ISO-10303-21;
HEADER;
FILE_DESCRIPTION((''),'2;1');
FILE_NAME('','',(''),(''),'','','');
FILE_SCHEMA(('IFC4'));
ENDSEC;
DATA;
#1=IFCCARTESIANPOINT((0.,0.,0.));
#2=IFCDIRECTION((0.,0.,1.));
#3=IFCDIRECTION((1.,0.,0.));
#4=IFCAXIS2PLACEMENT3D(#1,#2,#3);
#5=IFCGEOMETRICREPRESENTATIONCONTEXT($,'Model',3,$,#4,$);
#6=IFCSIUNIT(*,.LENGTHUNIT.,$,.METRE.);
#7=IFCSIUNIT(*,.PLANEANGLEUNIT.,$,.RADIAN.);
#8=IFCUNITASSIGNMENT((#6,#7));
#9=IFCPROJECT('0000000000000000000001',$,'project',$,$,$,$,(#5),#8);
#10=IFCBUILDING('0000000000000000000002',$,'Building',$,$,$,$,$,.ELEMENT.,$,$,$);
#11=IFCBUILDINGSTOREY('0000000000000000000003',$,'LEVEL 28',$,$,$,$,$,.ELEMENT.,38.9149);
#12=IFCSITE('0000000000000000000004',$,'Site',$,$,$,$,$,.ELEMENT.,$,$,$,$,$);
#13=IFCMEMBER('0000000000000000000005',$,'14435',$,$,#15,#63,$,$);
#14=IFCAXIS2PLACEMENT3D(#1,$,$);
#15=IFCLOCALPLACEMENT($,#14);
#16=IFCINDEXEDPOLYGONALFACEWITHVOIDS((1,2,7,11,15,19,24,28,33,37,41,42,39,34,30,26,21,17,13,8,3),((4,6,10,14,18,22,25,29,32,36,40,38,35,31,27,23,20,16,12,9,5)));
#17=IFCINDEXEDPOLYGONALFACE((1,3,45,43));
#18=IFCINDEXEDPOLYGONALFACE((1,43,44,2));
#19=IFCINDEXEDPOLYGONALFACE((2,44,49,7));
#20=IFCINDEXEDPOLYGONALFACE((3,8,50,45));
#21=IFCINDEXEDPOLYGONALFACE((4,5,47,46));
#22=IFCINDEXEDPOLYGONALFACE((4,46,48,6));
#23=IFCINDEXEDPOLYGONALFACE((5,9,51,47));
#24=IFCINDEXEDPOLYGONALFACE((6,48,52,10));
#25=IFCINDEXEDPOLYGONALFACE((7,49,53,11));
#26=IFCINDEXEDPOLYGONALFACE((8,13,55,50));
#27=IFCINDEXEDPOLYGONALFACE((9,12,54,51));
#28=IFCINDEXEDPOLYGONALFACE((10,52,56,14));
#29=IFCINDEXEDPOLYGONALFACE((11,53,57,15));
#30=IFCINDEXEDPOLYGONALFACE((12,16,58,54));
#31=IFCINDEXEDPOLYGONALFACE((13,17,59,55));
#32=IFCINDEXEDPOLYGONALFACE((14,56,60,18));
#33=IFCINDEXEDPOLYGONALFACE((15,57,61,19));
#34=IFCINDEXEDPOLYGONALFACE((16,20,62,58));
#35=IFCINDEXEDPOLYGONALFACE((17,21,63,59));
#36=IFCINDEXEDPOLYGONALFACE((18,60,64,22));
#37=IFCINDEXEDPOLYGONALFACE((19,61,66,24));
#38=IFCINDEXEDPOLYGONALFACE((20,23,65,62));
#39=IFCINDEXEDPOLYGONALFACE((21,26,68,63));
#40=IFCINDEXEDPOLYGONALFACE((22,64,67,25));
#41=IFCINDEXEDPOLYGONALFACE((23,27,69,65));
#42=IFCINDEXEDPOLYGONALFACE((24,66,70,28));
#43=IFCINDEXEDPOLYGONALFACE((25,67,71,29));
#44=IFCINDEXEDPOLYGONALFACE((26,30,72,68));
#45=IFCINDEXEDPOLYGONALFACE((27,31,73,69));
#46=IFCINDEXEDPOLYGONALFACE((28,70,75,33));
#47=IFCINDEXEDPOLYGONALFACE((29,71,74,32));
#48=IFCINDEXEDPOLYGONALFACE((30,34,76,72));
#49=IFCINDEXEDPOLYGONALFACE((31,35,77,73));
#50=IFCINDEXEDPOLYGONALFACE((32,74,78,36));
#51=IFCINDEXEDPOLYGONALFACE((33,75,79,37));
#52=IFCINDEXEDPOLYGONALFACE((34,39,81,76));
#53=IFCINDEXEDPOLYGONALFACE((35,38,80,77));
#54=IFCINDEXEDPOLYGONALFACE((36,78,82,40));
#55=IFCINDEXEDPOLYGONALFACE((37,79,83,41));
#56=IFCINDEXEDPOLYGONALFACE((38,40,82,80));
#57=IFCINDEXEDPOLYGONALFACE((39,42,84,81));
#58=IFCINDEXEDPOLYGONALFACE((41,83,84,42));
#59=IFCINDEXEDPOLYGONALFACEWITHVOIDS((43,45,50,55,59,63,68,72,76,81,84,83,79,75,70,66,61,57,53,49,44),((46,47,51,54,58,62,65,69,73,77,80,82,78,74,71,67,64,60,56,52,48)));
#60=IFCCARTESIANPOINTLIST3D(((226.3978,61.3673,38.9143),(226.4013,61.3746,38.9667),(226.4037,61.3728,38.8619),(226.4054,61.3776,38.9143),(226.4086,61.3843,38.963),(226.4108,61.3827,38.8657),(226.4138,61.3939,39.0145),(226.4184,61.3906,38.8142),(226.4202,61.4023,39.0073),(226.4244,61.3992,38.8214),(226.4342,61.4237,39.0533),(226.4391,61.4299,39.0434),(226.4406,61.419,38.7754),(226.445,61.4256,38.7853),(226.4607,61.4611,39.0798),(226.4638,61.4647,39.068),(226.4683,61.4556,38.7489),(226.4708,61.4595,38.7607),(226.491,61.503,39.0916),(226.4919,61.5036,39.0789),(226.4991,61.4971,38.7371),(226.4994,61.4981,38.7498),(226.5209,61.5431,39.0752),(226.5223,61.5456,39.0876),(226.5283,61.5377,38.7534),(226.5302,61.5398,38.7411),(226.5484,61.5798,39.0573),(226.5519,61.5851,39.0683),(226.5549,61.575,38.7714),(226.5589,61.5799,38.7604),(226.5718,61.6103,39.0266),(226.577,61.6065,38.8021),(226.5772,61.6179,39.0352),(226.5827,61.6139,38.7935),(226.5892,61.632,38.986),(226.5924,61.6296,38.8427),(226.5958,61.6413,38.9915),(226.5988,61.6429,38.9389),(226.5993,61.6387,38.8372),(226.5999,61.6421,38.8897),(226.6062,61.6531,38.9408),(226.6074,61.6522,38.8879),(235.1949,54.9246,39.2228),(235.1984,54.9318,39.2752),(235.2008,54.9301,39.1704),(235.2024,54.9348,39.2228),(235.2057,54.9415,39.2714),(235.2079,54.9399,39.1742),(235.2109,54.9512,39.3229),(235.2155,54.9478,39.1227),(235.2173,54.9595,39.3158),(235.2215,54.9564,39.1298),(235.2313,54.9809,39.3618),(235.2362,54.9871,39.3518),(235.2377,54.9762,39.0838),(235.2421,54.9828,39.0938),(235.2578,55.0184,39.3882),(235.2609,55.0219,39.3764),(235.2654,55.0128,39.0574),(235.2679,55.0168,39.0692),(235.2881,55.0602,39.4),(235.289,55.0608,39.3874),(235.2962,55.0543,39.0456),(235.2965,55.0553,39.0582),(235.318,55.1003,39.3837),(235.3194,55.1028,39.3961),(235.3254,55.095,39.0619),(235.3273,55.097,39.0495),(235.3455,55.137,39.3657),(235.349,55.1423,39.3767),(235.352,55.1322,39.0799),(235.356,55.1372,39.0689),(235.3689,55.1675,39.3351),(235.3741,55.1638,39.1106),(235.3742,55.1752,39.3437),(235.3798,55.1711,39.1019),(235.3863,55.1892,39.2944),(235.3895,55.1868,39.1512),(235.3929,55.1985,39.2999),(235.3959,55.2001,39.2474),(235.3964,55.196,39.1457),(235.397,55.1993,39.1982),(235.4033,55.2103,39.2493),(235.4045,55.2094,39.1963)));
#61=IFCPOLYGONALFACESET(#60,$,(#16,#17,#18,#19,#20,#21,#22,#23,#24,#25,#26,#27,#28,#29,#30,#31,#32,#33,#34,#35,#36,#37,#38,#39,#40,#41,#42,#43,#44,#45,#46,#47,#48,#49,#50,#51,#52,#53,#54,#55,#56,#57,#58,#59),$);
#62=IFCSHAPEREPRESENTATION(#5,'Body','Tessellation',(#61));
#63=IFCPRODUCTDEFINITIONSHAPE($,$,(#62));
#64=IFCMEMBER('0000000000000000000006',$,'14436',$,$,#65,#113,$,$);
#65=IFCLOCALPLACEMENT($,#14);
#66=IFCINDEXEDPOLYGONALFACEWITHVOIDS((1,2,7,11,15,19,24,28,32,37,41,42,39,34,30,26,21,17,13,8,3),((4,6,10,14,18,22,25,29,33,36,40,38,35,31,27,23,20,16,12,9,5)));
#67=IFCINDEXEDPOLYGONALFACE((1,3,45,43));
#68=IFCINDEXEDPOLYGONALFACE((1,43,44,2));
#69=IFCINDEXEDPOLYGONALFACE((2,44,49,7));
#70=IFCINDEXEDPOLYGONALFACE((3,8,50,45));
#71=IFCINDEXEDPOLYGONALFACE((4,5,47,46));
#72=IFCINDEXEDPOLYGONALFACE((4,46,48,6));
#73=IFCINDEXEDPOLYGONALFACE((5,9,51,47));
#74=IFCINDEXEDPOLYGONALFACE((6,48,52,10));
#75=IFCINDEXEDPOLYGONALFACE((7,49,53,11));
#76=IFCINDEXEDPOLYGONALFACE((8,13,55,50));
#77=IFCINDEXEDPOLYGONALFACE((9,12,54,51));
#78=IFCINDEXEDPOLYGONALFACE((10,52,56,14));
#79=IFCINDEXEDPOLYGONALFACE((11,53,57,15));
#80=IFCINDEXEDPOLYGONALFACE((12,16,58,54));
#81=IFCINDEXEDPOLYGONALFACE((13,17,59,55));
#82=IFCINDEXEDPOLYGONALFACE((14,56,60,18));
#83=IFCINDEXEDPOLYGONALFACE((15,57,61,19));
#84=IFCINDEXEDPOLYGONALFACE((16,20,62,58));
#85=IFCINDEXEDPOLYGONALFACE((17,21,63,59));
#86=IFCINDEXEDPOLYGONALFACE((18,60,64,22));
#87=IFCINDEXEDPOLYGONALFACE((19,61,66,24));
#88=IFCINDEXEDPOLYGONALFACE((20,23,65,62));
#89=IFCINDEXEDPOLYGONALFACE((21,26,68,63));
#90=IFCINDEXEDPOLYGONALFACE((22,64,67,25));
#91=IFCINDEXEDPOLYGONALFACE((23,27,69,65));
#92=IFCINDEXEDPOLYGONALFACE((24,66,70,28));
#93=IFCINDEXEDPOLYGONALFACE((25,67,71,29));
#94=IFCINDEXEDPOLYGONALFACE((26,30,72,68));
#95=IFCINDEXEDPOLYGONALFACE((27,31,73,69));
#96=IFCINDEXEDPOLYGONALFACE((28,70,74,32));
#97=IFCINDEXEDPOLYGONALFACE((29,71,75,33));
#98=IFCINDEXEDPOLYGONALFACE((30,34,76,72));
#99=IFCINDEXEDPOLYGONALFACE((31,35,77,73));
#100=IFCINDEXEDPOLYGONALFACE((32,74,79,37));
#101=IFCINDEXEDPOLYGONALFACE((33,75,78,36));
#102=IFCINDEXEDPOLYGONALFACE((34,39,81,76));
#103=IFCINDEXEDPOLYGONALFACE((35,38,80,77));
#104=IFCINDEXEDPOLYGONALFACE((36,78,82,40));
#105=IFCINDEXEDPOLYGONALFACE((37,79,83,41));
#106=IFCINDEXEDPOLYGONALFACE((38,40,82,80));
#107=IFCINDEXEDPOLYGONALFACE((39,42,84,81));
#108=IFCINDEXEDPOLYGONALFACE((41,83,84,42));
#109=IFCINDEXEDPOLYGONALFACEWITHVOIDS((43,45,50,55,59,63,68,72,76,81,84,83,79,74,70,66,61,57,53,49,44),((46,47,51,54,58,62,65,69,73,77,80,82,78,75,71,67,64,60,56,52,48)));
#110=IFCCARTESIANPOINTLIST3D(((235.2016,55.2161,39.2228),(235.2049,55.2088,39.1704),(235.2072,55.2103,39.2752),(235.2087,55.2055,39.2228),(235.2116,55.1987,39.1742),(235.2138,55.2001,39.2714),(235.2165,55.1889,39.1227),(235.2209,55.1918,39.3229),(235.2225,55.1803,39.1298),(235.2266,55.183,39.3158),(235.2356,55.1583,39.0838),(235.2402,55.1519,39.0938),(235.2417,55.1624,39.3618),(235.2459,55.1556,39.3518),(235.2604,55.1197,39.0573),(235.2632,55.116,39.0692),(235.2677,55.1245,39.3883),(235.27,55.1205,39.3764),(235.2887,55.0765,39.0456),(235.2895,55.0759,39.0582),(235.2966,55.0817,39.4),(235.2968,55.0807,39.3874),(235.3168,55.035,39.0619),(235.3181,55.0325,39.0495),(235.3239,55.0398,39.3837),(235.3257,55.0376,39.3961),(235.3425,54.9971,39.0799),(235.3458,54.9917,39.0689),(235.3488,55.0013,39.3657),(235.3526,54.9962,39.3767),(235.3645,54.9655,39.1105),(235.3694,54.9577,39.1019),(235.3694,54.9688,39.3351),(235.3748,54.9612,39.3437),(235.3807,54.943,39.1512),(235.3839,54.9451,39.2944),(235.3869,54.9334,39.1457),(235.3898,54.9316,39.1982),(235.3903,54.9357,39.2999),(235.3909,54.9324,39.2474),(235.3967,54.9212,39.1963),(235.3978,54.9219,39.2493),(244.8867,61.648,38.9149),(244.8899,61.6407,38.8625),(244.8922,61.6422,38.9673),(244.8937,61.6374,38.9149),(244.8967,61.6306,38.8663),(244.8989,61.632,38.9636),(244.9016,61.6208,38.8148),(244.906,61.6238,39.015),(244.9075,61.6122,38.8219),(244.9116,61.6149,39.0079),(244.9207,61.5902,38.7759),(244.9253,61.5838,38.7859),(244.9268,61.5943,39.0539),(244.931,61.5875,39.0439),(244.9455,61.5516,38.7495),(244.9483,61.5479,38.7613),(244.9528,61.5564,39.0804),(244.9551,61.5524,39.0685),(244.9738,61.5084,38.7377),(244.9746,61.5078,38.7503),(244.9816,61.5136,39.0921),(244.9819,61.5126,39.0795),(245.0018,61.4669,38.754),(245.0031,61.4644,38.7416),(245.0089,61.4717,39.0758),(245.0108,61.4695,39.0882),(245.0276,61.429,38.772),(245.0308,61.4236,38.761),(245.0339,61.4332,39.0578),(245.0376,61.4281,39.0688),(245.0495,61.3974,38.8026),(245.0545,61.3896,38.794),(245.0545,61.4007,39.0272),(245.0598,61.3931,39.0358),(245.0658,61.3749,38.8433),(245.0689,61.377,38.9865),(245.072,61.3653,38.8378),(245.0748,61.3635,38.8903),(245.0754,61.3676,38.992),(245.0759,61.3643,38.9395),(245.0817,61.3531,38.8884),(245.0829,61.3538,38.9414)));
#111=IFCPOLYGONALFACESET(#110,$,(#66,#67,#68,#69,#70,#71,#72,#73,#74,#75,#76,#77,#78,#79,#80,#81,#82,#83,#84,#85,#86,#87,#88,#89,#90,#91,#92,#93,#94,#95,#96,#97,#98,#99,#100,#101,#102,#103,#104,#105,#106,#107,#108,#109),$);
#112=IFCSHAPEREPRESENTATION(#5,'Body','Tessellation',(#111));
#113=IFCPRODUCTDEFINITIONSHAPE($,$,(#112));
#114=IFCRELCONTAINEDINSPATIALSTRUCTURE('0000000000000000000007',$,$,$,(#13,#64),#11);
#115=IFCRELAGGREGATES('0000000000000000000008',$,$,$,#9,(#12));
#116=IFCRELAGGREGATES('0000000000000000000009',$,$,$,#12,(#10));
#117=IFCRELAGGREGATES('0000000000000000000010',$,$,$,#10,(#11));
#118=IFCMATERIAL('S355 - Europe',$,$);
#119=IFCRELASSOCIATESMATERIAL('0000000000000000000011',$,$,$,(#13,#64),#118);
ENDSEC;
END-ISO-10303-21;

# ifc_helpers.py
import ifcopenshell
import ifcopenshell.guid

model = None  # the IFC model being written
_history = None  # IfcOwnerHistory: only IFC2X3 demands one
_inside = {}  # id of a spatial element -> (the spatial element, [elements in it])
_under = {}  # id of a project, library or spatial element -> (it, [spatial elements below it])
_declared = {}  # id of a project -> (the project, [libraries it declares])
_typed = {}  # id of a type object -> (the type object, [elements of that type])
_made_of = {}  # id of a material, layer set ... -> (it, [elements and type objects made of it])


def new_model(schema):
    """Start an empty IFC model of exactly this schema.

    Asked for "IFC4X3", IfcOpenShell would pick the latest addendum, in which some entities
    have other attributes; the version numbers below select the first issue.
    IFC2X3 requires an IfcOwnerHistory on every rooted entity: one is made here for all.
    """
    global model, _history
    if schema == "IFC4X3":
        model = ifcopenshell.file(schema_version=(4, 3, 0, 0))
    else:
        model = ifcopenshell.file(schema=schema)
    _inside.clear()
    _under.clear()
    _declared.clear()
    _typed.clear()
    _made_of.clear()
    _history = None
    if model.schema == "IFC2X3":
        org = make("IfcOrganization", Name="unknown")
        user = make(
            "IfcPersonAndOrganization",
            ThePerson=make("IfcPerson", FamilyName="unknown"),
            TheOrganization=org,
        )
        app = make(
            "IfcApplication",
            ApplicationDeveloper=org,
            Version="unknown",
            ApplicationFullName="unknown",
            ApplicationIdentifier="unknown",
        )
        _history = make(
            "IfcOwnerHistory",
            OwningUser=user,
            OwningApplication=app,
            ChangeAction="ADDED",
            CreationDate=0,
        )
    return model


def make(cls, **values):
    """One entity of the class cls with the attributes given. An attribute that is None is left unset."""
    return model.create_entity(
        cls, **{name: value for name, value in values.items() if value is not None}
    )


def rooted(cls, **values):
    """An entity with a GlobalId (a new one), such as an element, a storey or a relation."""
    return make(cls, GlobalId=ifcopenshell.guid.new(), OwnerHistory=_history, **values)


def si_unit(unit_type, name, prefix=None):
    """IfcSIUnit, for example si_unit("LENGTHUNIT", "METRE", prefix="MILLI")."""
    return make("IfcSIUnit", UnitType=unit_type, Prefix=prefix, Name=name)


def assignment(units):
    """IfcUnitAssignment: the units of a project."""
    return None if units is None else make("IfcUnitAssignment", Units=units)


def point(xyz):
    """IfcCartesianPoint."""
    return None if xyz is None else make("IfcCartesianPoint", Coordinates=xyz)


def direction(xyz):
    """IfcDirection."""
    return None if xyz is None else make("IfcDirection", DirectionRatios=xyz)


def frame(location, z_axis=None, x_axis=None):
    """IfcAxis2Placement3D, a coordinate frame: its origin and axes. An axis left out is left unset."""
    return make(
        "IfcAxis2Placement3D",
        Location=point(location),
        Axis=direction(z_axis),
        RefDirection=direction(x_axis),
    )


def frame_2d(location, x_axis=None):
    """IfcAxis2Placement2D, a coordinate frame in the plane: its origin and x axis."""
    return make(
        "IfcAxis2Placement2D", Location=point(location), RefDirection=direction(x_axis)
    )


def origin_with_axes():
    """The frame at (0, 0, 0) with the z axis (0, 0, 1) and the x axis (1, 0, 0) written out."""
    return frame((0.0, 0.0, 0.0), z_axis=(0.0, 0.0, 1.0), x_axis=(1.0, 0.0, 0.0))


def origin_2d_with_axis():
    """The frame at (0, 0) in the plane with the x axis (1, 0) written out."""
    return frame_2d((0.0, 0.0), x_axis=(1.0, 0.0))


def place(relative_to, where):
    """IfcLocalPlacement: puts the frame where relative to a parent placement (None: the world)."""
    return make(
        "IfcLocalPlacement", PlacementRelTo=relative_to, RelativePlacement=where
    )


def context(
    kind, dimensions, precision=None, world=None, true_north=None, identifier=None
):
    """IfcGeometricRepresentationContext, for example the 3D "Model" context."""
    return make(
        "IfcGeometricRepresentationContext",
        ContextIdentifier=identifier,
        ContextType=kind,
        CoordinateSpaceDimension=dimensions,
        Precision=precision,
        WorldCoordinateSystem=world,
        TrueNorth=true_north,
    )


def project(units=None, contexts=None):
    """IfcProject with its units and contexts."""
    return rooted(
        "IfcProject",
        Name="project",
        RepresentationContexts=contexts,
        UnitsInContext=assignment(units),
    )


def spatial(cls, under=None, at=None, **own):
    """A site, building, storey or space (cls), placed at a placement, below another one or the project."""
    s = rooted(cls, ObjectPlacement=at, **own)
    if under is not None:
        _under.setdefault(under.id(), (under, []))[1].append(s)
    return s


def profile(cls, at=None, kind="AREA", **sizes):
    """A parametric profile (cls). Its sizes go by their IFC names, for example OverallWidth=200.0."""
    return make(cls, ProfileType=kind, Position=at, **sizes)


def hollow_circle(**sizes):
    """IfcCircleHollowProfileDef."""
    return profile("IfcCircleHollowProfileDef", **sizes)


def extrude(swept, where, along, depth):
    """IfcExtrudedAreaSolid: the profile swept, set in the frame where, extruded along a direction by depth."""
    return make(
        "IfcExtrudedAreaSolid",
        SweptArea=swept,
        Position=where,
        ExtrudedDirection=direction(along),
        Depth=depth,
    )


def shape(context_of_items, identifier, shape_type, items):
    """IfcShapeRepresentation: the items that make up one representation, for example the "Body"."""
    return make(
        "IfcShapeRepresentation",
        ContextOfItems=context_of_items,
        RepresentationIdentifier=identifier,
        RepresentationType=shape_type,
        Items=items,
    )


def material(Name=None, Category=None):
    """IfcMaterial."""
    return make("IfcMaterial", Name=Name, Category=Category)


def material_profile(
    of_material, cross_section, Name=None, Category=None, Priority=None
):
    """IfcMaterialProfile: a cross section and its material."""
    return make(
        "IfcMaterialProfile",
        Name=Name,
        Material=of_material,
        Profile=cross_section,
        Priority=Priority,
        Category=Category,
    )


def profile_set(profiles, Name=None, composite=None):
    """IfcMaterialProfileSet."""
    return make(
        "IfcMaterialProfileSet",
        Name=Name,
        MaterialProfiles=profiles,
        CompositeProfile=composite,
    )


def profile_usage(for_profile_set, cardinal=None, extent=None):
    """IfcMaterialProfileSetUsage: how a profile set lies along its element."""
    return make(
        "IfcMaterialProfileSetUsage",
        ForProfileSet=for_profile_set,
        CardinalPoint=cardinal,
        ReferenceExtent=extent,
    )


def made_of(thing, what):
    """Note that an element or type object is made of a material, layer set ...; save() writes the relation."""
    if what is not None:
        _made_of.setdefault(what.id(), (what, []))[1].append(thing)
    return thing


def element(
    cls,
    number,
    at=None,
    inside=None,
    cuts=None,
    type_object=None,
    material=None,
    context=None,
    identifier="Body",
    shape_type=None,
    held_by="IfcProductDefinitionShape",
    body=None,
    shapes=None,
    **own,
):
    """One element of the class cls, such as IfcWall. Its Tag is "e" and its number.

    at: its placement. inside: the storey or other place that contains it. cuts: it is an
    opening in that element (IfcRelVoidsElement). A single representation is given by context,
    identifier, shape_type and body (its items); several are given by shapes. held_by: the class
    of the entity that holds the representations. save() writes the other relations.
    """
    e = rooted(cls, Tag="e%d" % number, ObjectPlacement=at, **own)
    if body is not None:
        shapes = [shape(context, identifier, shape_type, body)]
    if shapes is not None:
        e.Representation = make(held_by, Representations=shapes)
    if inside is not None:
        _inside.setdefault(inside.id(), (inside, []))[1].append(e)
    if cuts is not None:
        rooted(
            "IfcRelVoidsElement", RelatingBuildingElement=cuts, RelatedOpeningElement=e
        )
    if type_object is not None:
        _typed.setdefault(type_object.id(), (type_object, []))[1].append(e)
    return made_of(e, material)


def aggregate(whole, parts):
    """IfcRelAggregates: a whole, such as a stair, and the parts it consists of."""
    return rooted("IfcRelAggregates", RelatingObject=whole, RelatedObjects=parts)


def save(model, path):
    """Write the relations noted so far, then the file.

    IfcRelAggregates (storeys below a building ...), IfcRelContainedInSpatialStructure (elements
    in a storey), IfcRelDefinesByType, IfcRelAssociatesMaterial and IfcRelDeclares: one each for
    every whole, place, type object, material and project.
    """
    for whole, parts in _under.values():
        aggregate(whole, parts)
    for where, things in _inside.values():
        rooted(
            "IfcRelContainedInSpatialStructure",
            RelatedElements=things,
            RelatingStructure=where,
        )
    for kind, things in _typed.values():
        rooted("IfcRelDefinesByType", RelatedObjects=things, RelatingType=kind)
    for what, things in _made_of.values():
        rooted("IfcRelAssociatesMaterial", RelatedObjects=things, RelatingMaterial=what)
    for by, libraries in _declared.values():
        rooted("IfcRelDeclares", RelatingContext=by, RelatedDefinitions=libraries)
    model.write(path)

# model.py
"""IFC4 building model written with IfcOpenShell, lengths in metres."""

from ifc_helpers import new_model, si_unit, frame, origin_with_axes, origin_2d_with_axis, place, context, project, spatial, hollow_circle, extrude, material, material_profile, profile_set, profile_usage, element, save


model = new_model("IFC4")

# Units and contexts
model_context = context("Model", 3, world=origin_with_axes())
ifc_project = project(units=[si_unit("LENGTHUNIT", "METRE"), si_unit("PLANEANGLEUNIT", "RADIAN")], contexts=[model_context])

# Site, building, storey
site = spatial("IfcSite", under=ifc_project, Name="Site", CompositionType="ELEMENT")
building = spatial("IfcBuilding", under=site, Name="Building", CompositionType="ELEMENT")
storey = spatial("IfcBuildingStorey", under=building, Name="LEVEL 28", CompositionType="ELEMENT", Elevation=38.9149)

# Shared definitions
ifc_material = material(Name="S355 - Europe")

# Members
ifc_material_profile_1 = material_profile(ifc_material, hollow_circle(Radius=0.1778, WallThickness=0.0127, at=origin_2d_with_axis()))
ifc_profile_set_1 = profile_set([ifc_material_profile_1])
ifc_profile_usage_1 = profile_usage(ifc_profile_set_1, cardinal=10)
member_1_placement = place(None, frame((235.3, 55.068, 39.2228), z_axis=(-0.806451, 0.590625, -0.028277), x_axis=(-0.589956, -0.807435, 0.0)))
element("IfcMember", 1, at=member_1_placement, inside=storey, material=ifc_profile_usage_1, Name="14435", context=model_context, shape_type="SweptSolid", body=[
    extrude(hollow_circle(Radius=0.1778, WallThickness=0.0127, at=origin_2d_with_axis()), origin_with_axes(), (0.0, 0.0, 1.0), 10.9084),
])
ifc_material_profile_2 = material_profile(ifc_material, hollow_circle(Radius=0.1778, WallThickness=0.0127, at=origin_2d_with_axis()))
ifc_profile_set_2 = profile_set([ifc_material_profile_2])
ifc_profile_usage_2 = profile_usage(ifc_profile_set_2, cardinal=10)
member_2_placement = place(None, frame((235.3, 55.068, 39.2228), z_axis=(0.832742, 0.553029, -0.026473), x_axis=(-0.553223, 0.833033, 0.0)))
element("IfcMember", 2, at=member_2_placement, inside=storey, material=ifc_profile_usage_2, Name="14436", context=model_context, shape_type="SweptSolid", body=[
    extrude(hollow_circle(Radius=0.1778, WallThickness=0.0127, at=origin_2d_with_axis()), origin_with_axes(), (0.0, 0.0, 1.0), 11.6303),
])

save(model, "model.ifc")
